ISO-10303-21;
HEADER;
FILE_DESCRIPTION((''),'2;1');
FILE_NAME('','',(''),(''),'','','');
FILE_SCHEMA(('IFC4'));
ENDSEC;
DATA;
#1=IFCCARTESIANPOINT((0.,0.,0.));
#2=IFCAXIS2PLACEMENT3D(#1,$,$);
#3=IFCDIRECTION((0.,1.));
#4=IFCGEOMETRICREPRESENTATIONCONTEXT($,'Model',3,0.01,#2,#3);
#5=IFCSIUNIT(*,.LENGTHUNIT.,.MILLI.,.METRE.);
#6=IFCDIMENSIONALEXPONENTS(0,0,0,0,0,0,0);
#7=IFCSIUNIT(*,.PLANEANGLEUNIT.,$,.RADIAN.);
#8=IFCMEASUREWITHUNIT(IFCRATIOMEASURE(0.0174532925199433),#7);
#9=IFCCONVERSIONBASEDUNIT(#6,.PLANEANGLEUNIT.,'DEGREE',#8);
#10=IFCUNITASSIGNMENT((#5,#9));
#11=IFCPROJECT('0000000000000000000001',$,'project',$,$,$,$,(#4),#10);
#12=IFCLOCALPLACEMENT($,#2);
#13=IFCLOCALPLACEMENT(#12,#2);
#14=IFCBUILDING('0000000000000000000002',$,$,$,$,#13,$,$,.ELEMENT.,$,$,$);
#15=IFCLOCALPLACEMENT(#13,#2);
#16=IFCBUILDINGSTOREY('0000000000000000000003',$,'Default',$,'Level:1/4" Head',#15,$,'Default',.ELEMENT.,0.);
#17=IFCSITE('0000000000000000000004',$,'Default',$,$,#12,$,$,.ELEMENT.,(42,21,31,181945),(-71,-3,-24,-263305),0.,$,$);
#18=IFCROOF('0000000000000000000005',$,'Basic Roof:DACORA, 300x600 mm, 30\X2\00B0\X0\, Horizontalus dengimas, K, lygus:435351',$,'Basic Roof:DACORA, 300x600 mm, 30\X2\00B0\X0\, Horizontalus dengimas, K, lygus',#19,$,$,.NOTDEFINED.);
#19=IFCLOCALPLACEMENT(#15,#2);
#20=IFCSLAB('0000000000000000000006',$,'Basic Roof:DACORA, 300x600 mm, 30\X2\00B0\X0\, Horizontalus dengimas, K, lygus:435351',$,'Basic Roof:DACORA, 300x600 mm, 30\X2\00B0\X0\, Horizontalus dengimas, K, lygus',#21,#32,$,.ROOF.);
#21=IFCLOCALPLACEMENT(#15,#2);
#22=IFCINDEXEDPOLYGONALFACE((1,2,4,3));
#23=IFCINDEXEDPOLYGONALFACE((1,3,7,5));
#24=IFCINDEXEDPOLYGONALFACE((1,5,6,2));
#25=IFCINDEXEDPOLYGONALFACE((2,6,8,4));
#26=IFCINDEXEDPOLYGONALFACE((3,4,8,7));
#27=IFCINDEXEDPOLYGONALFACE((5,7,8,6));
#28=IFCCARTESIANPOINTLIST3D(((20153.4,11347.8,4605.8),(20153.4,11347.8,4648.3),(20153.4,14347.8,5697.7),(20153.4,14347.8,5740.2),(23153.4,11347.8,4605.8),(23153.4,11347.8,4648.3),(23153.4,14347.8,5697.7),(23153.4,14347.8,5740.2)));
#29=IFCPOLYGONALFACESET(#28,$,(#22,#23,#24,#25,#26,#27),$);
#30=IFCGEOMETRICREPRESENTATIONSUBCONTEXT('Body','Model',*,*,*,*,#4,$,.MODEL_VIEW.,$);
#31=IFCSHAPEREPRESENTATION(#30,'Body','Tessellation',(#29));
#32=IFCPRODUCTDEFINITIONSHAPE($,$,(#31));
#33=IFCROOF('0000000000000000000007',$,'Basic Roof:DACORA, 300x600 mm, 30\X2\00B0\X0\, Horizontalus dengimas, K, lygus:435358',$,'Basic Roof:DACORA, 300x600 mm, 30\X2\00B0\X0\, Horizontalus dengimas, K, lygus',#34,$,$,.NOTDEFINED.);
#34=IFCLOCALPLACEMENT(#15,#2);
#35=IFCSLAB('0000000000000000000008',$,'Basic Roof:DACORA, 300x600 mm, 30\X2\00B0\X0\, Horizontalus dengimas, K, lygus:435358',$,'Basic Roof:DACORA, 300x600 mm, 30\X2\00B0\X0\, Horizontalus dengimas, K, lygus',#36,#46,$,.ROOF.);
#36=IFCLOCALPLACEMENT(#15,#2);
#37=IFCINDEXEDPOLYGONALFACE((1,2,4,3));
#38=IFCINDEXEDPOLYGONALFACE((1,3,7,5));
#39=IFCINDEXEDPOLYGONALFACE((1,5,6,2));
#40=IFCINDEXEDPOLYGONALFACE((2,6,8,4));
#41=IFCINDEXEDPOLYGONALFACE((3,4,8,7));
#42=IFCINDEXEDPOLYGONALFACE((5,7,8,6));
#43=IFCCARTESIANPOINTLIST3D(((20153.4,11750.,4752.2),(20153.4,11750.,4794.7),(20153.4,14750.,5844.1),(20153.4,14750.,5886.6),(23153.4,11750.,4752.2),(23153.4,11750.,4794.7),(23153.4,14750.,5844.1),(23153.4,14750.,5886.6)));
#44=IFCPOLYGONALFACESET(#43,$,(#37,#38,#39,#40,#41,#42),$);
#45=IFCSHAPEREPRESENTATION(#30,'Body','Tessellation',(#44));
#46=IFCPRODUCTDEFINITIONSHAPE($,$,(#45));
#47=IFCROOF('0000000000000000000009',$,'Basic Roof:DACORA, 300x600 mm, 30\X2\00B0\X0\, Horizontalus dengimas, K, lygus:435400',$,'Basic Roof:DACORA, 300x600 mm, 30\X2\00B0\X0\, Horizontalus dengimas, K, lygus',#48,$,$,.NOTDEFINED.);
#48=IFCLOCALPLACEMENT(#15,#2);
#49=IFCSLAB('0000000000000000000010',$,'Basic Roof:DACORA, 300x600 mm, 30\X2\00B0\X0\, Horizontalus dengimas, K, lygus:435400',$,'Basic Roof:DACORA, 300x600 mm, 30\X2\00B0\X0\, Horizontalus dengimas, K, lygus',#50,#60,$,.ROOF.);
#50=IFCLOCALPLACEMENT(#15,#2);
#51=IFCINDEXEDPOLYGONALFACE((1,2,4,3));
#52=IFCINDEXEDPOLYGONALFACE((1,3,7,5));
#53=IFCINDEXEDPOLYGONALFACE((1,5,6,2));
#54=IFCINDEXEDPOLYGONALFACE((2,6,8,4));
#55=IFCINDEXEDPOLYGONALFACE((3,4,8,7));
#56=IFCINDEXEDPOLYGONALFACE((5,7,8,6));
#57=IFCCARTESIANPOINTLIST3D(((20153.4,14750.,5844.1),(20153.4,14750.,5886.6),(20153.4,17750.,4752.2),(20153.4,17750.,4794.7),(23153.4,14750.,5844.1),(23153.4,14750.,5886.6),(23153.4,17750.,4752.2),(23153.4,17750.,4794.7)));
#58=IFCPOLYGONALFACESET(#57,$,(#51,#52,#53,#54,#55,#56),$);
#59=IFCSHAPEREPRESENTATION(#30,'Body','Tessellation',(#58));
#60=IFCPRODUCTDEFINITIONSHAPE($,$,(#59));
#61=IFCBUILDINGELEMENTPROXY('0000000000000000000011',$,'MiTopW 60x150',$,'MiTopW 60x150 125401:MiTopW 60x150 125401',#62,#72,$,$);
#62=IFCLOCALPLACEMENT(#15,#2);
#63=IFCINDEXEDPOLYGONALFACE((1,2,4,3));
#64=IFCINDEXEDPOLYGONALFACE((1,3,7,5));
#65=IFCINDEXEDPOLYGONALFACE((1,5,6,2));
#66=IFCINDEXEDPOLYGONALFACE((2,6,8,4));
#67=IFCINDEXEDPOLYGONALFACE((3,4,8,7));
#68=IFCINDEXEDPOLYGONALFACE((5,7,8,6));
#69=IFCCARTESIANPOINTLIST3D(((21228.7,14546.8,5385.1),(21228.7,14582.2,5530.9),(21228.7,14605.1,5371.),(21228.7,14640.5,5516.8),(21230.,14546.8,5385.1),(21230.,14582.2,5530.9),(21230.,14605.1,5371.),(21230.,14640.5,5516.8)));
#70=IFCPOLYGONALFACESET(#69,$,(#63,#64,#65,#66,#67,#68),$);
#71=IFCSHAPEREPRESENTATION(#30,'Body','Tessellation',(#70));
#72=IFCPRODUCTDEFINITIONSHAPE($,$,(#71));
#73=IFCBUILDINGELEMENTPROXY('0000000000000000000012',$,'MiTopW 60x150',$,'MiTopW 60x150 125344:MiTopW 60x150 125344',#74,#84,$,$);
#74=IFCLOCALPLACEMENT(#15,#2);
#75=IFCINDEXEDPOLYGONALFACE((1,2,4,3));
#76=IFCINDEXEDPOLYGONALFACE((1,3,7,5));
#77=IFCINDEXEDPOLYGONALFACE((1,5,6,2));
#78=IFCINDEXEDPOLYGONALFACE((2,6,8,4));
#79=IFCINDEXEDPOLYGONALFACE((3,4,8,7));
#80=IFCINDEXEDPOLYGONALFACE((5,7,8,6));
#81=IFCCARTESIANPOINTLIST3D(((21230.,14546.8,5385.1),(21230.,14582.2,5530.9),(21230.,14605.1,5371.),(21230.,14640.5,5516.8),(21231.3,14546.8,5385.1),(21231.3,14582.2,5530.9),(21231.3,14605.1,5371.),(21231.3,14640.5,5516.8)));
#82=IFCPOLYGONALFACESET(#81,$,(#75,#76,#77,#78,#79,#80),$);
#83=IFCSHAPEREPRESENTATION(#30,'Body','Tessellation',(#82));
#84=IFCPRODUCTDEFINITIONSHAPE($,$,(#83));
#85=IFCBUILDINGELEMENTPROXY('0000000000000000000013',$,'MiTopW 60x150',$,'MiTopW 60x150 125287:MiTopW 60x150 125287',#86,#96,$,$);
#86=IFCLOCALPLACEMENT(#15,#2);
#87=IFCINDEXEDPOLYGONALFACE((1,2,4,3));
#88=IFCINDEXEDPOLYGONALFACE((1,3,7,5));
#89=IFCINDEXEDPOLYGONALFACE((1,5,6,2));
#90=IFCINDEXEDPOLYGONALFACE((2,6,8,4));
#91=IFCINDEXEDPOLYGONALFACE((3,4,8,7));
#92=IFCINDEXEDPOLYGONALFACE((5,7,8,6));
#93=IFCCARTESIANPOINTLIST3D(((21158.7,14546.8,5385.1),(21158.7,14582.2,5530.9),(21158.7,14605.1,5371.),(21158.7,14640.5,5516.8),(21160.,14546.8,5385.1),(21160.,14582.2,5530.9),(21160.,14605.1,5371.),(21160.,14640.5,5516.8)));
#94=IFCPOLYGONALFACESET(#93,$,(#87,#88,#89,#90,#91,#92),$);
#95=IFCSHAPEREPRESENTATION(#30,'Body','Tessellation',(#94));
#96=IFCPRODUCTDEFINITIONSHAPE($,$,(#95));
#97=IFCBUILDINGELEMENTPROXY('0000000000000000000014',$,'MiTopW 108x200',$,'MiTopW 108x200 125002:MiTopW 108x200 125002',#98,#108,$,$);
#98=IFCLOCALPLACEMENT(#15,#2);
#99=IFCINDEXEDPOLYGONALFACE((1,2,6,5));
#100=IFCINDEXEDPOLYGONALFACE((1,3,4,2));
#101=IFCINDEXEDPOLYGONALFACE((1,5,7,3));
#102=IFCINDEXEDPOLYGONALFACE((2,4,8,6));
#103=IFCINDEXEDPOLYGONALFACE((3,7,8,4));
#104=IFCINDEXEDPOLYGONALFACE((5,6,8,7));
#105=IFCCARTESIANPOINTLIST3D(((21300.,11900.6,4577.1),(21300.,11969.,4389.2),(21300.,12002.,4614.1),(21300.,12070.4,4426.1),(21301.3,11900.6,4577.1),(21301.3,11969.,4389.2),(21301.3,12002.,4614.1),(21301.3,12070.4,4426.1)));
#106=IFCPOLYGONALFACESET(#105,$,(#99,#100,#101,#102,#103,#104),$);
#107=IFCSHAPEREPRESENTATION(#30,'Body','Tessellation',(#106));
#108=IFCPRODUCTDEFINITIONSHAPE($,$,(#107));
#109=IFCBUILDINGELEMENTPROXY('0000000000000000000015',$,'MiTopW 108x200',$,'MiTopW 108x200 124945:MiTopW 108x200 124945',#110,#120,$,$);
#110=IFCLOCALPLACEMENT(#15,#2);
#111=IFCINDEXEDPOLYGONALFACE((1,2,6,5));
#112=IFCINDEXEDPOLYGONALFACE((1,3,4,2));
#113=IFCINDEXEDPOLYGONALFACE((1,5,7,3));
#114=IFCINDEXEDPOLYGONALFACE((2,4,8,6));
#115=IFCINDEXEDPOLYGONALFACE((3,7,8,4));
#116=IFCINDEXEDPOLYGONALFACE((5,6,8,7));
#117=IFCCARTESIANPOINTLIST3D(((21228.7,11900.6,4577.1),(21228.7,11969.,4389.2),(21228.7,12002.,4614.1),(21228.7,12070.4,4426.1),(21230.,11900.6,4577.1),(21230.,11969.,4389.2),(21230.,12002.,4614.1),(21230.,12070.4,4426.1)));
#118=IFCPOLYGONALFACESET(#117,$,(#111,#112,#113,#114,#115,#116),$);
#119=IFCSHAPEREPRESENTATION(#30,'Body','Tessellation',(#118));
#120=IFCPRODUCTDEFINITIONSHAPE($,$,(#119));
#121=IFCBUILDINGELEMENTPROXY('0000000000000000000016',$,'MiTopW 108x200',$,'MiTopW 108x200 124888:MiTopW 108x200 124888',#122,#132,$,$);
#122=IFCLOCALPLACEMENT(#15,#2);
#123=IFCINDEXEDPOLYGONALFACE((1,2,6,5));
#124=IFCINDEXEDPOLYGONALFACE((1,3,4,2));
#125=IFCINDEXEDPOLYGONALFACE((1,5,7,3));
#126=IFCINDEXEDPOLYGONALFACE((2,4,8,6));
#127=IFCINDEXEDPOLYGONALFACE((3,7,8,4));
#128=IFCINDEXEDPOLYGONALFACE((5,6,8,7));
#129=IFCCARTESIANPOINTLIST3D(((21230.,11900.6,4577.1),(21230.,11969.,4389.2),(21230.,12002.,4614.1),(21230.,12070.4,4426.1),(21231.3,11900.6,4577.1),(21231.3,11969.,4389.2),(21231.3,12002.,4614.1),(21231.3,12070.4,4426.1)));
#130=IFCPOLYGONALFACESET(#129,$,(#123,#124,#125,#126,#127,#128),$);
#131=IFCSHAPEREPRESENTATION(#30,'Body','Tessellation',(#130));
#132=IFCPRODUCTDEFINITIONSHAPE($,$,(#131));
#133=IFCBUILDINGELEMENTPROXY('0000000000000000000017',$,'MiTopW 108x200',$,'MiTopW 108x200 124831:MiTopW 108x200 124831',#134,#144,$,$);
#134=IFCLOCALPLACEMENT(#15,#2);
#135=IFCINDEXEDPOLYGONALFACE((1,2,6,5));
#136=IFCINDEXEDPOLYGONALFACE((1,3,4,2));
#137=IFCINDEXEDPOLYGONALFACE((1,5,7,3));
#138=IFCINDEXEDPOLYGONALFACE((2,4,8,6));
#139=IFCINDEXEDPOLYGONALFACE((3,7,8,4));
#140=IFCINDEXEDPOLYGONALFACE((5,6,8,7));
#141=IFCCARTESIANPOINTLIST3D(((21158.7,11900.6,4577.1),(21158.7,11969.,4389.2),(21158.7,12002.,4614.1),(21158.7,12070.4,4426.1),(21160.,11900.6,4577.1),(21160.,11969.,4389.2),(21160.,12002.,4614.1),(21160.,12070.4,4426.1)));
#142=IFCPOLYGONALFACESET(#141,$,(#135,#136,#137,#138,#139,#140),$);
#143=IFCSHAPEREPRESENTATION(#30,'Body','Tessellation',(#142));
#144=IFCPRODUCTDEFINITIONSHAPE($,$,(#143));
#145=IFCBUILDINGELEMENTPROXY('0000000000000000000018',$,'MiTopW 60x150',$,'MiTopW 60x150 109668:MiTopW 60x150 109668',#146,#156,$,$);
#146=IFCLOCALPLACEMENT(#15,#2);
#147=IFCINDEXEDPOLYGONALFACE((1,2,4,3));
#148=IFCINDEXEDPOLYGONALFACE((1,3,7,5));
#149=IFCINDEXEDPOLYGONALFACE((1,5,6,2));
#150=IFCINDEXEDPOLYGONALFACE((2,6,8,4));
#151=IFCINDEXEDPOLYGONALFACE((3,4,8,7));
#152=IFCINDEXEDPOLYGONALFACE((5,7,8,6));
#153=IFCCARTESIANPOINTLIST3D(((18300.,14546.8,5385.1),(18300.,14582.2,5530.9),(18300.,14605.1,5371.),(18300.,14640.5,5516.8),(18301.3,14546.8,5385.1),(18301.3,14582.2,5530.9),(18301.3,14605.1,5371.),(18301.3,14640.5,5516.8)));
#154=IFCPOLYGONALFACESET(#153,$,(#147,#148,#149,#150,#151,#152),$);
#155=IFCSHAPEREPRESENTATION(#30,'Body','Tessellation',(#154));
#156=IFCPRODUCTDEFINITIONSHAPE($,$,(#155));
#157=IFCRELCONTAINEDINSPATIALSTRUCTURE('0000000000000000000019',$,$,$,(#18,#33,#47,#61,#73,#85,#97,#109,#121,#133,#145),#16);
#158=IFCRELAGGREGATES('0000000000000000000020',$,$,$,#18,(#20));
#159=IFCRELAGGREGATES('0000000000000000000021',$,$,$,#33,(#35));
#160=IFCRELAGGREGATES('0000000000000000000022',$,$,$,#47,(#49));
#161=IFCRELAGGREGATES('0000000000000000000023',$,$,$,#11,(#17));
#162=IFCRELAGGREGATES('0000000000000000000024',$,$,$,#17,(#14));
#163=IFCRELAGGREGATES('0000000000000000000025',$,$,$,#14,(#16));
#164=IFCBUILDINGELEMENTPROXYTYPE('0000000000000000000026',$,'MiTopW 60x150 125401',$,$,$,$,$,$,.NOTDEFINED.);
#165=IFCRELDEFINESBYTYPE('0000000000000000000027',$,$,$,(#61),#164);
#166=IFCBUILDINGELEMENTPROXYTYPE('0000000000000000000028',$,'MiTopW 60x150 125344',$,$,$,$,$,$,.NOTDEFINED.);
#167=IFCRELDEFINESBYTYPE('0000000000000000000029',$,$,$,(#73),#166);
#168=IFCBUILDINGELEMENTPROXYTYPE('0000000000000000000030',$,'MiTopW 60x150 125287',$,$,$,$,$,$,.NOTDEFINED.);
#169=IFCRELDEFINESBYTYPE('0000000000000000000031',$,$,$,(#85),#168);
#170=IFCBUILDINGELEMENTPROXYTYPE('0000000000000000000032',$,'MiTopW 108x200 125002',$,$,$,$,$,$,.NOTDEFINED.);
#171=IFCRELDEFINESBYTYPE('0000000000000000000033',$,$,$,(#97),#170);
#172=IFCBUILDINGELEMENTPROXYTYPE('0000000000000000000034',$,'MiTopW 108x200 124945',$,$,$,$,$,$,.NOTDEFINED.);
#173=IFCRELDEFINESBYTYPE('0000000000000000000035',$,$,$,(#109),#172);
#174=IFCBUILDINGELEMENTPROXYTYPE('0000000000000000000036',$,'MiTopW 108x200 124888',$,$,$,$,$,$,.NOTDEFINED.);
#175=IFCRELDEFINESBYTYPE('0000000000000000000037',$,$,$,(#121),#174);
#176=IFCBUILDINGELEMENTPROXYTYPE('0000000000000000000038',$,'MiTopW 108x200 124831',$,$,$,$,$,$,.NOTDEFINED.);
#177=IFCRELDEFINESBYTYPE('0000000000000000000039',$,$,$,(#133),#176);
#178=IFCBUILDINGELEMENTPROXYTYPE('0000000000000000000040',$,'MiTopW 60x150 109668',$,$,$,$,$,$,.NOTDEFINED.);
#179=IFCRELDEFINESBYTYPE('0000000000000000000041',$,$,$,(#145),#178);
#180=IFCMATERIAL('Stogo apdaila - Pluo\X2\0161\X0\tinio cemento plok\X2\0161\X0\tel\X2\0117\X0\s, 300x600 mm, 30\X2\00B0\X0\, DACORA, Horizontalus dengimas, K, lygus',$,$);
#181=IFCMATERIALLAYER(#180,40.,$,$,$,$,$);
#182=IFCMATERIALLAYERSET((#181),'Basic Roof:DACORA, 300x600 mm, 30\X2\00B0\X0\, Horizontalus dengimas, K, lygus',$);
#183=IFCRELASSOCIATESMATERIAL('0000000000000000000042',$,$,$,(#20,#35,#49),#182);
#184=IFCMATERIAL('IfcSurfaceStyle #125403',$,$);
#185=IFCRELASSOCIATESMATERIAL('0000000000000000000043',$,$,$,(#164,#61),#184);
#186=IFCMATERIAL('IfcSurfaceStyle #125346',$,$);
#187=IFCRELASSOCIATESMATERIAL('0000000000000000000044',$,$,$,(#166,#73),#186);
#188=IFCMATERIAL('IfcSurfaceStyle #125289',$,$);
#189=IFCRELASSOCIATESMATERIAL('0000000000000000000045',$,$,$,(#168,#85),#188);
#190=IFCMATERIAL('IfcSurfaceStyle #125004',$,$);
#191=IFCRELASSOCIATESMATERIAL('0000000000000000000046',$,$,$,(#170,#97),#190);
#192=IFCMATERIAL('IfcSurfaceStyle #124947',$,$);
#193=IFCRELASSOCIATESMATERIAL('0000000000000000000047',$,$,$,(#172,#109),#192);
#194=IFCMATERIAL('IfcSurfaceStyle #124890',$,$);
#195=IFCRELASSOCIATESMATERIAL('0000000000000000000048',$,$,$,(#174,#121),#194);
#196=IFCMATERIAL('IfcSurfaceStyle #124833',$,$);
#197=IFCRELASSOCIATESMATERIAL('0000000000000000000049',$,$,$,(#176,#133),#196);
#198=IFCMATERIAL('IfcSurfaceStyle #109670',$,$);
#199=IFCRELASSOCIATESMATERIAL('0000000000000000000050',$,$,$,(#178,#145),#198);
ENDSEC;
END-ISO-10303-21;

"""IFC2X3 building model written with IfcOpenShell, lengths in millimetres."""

from ifc_helpers import new_model, entity, si_unit, converted_unit, direction, frame, frame_2d, origin, place, context, subcontext, project, spatial, polyline, rectangle, outline, extrude, source, transform, mapped, material, layer, layer_set, type_object, type_shapes, element, aggregate, save


model = new_model("IFC2X3")

# Units and contexts
model_context = context("Model", 3, precision=0.01, world=origin(), true_north=direction((0.0, 1.0)))
body_context = subcontext(model_context, "Body", "Model", "MODEL_VIEW")
ifc_project = project(units=[si_unit("LENGTHUNIT", "METRE", prefix="MILLI"), converted_unit("PLANEANGLEUNIT", "DEGREE", entity("IfcRatioMeasure", 0.0174532925199433), si_unit("PLANEANGLEUNIT", "RADIAN"), dimensions=[0, 0, 0, 0, 0, 0, 0])], contexts=[model_context])

# Site, building, storey
site_placement = place(None, origin())
site = spatial("IfcSite", under=ifc_project, at=site_placement, Name="Default", CompositionType="ELEMENT", RefLatitude=(42, 21, 31, 181945), RefLongitude=(-71, -3, -24, -263305), RefElevation=0.0)
building_placement = place(site_placement, origin())
building = spatial("IfcBuilding", under=site, at=building_placement, CompositionType="ELEMENT")
storey_placement = place(building_placement, origin())
storey = spatial("IfcBuildingStorey", under=building, at=storey_placement, Name="Default", ObjectType="Level:1/4\" Head", LongName="Default", CompositionType="ELEMENT", Elevation=0.0)

# Roofs, slabs
roof_1_placement = place(storey_placement, frame((20153.4, 11347.8, 4605.8)))
roof_1 = element("IfcRoof", 1, at=roof_1_placement, inside=storey, Name="Basic Roof:DACORA, 300x600 mm, 30°, Horizontalus dengimas, K, lygus:435351", ObjectType="Basic Roof:DACORA, 300x600 mm, 30°, Horizontalus dengimas, K, lygus", ShapeType="NOTDEFINED")
ifc_material_1 = material(Name="Stogo apdaila - Pluoštinio cemento plokštelės, 300x600 mm, 30°, DACORA, Horizontalus dengimas, K, lygus")
ifc_layer = layer(ifc_material_1, 40.0)
ifc_layer_set = layer_set([ifc_layer], Name="Basic Roof:DACORA, 300x600 mm, 30°, Horizontalus dengimas, K, lygus")
slab_1_placement = place(roof_1_placement, origin())
slab_1 = element("IfcSlab", 2, at=slab_1_placement, material=ifc_layer_set, Name="Basic Roof:DACORA, 300x600 mm, 30°, Horizontalus dengimas, K, lygus:435351", ObjectType="Basic Roof:DACORA, 300x600 mm, 30°, Horizontalus dengimas, K, lygus", PredefinedType="ROOF", context=body_context, shape_type="SweptSolid", body=[
    extrude(rectangle(XDim=3192.5, YDim=3000.0, at=frame_2d((0.0, 0.0), x_axis=(0.0, -1.0))), frame((1500.0, 1500.0, 546.0), z_axis=(0.0, -0.34202, 0.939693), x_axis=(1.0, 0.0, 0.0)), (0.0, 0.34202, 0.939693), 42.6),
])
aggregate(roof_1, [slab_1])
roof_2_placement = place(storey_placement, frame((20153.4, 11750.0, 4752.2)))
roof_2 = element("IfcRoof", 3, at=roof_2_placement, inside=storey, Name="Basic Roof:DACORA, 300x600 mm, 30°, Horizontalus dengimas, K, lygus:435358", ObjectType="Basic Roof:DACORA, 300x600 mm, 30°, Horizontalus dengimas, K, lygus", ShapeType="NOTDEFINED")
slab_2_placement = place(roof_2_placement, origin())
slab_2 = element("IfcSlab", 4, at=slab_2_placement, material=ifc_layer_set, Name="Basic Roof:DACORA, 300x600 mm, 30°, Horizontalus dengimas, K, lygus:435358", ObjectType="Basic Roof:DACORA, 300x600 mm, 30°, Horizontalus dengimas, K, lygus", PredefinedType="ROOF", context=body_context, shape_type="SweptSolid", body=[
    extrude(rectangle(XDim=3192.5, YDim=3000.0, at=frame_2d((0.0, 0.0), x_axis=(0.0, -1.0))), frame((1500.0, 1500.0, 546.0), z_axis=(0.0, -0.34202, 0.939693), x_axis=(1.0, 0.0, 0.0)), (0.0, 0.34202, 0.939693), 42.6),
])
aggregate(roof_2, [slab_2])
roof_3_placement = place(storey_placement, frame((20153.4, 14750.0, 4752.2)))
roof_3 = element("IfcRoof", 5, at=roof_3_placement, inside=storey, Name="Basic Roof:DACORA, 300x600 mm, 30°, Horizontalus dengimas, K, lygus:435400", ObjectType="Basic Roof:DACORA, 300x600 mm, 30°, Horizontalus dengimas, K, lygus", ShapeType="NOTDEFINED")
slab_3_placement = place(roof_3_placement, origin())
slab_3 = element("IfcSlab", 6, at=slab_3_placement, material=ifc_layer_set, Name="Basic Roof:DACORA, 300x600 mm, 30°, Horizontalus dengimas, K, lygus:435400", ObjectType="Basic Roof:DACORA, 300x600 mm, 30°, Horizontalus dengimas, K, lygus", PredefinedType="ROOF", context=body_context, shape_type="SweptSolid", body=[
    extrude(rectangle(XDim=3192.5, YDim=3000.0, at=frame_2d((0.0, 0.0), x_axis=(0.0, 1.0))), frame((1500.0, 1500.0, 546.0), z_axis=(0.0, 0.34202, 0.939693), x_axis=(1.0, 0.0, 0.0)), (0.0, -0.34202, 0.939693), 42.6),
])
aggregate(roof_3, [slab_3])

# Building element proxies
ifc_material_2 = material(Name="IfcSurfaceStyle #125403")
building_element_proxy_type_1 = type_object("IfcBuildingElementProxyType", Name="MiTopW 60x150 125401", PredefinedType="NOTDEFINED", material=ifc_material_2)
shared_shape_1 = source(origin(), body_context, "Body", "SweptSolid", [
    extrude(outline(polyline([(-75.0, -30.0), (75.0, -30.0), (75.0, 30.0), (-75.0, 30.0), (-75.0, -30.0)])), frame((75.0, 30.0, 0.0), z_axis=(0.0, 0.0, 1.0), x_axis=(-1.0, 0.0, 0.0)), (0.0, 0.0, 1.0), 1.3),
])
type_shapes(building_element_proxy_type_1, [shared_shape_1])
proxy_1_placement = place(building_placement, frame((21230.0, 14640.5, 5516.8), z_axis=(-1.0, 0.0, 0.0), x_axis=(0.0, -0.235626, -0.971844)))
element("IfcBuildingElementProxy", 7, at=proxy_1_placement, inside=storey, type_object=building_element_proxy_type_1, material=ifc_material_2, Name="MiTopW 60x150", ObjectType="MiTopW 60x150 125401:MiTopW 60x150 125401", context=body_context, shape_type="MappedRepresentation", body=[
    mapped(shared_shape_1, transform((0.0, 0.0, 0.0), scale=1.0)),
])
ifc_material_3 = material(Name="IfcSurfaceStyle #125346")
building_element_proxy_type_2 = type_object("IfcBuildingElementProxyType", Name="MiTopW 60x150 125344", PredefinedType="NOTDEFINED", material=ifc_material_3)
shared_shape_2 = source(origin(), body_context, "Body", "SweptSolid", [
    extrude(outline(polyline([(-75.0, -30.0), (75.0, -30.0), (75.0, 30.0), (-75.0, 30.0), (-75.0, -30.0)])), frame((75.0, 30.0, 0.0), z_axis=(0.0, 0.0, 1.0), x_axis=(-1.0, 0.0, 0.0)), (0.0, 0.0, 1.0), 1.3),
])
type_shapes(building_element_proxy_type_2, [shared_shape_2])
proxy_2_placement = place(building_placement, frame((21231.3, 14640.5, 5516.8), z_axis=(-1.0, 0.0, 0.0), x_axis=(0.0, -0.235626, -0.971844)))
element("IfcBuildingElementProxy", 8, at=proxy_2_placement, inside=storey, type_object=building_element_proxy_type_2, material=ifc_material_3, Name="MiTopW 60x150", ObjectType="MiTopW 60x150 125344:MiTopW 60x150 125344", context=body_context, shape_type="MappedRepresentation", body=[
    mapped(shared_shape_2, transform((0.0, 0.0, 0.0), scale=1.0)),
])
ifc_material_4 = material(Name="IfcSurfaceStyle #125289")
building_element_proxy_type_3 = type_object("IfcBuildingElementProxyType", Name="MiTopW 60x150 125287", PredefinedType="NOTDEFINED", material=ifc_material_4)
shared_shape_3 = source(origin(), body_context, "Body", "SweptSolid", [
    extrude(outline(polyline([(-75.0, -30.0), (75.0, -30.0), (75.0, 30.0), (-75.0, 30.0), (-75.0, -30.0)])), frame((75.0, 30.0, 0.0), z_axis=(0.0, 0.0, 1.0), x_axis=(-1.0, 0.0, 0.0)), (0.0, 0.0, 1.0), 1.3),
])
type_shapes(building_element_proxy_type_3, [shared_shape_3])
proxy_3_placement = place(building_placement, frame((21160.0, 14640.5, 5516.8), z_axis=(-1.0, 0.0, 0.0), x_axis=(0.0, -0.235626, -0.971844)))
element("IfcBuildingElementProxy", 9, at=proxy_3_placement, inside=storey, type_object=building_element_proxy_type_3, material=ifc_material_4, Name="MiTopW 60x150", ObjectType="MiTopW 60x150 125287:MiTopW 60x150 125287", context=body_context, shape_type="MappedRepresentation", body=[
    mapped(shared_shape_3, transform((0.0, 0.0, 0.0), scale=1.0)),
])
ifc_material_5 = material(Name="IfcSurfaceStyle #125004")
building_element_proxy_type_4 = type_object("IfcBuildingElementProxyType", Name="MiTopW 108x200 125002", PredefinedType="NOTDEFINED", material=ifc_material_5)
shared_shape_4 = source(origin(), body_context, "Body", "SweptSolid", [
    extrude(outline(polyline([(-54.0, -100.0), (54.0, -100.0), (54.0, 100.0), (-54.0, 100.0), (-54.0, -100.0)])), frame((100.0, 54.0, 0.0), z_axis=(0.0, 0.0, 1.0), x_axis=(-0.000002, 1.0, 0.0)), (0.0, 0.0, 1.0), 1.3),
])
type_shapes(building_element_proxy_type_4, [shared_shape_4])
proxy_4_placement = place(building_placement, frame((21301.3, 12002.0, 4614.1), z_axis=(-1.0, 0.0, 0.0), x_axis=(0.0, 0.34202, -0.939693)))
element("IfcBuildingElementProxy", 10, at=proxy_4_placement, inside=storey, type_object=building_element_proxy_type_4, material=ifc_material_5, Name="MiTopW 108x200", ObjectType="MiTopW 108x200 125002:MiTopW 108x200 125002", context=body_context, shape_type="MappedRepresentation", body=[
    mapped(shared_shape_4, transform((0.0, 0.0, 0.0), scale=1.0)),
])
ifc_material_6 = material(Name="IfcSurfaceStyle #124947")
building_element_proxy_type_5 = type_object("IfcBuildingElementProxyType", Name="MiTopW 108x200 124945", PredefinedType="NOTDEFINED", material=ifc_material_6)
shared_shape_5 = source(origin(), body_context, "Body", "SweptSolid", [
    extrude(outline(polyline([(-54.0, -100.0), (54.0, -100.0), (54.0, 100.0), (-54.0, 100.0), (-54.0, -100.0)])), frame((100.0, 54.0, 0.0), z_axis=(0.0, 0.0, 1.0), x_axis=(-0.000002, 1.0, 0.0)), (0.0, 0.0, 1.0), 1.3),
])
type_shapes(building_element_proxy_type_5, [shared_shape_5])
proxy_5_placement = place(building_placement, frame((21230.0, 12002.0, 4614.1), z_axis=(-1.0, 0.0, 0.0), x_axis=(0.0, 0.34202, -0.939693)))
element("IfcBuildingElementProxy", 11, at=proxy_5_placement, inside=storey, type_object=building_element_proxy_type_5, material=ifc_material_6, Name="MiTopW 108x200", ObjectType="MiTopW 108x200 124945:MiTopW 108x200 124945", context=body_context, shape_type="MappedRepresentation", body=[
    mapped(shared_shape_5, transform((0.0, 0.0, 0.0), scale=1.0)),
])
ifc_material_7 = material(Name="IfcSurfaceStyle #124890")
building_element_proxy_type_6 = type_object("IfcBuildingElementProxyType", Name="MiTopW 108x200 124888", PredefinedType="NOTDEFINED", material=ifc_material_7)
shared_shape_6 = source(origin(), body_context, "Body", "SweptSolid", [
    extrude(outline(polyline([(-54.0, -100.0), (54.0, -100.0), (54.0, 100.0), (-54.0, 100.0), (-54.0, -100.0)])), frame((100.0, 54.0, 0.0), z_axis=(0.0, 0.0, 1.0), x_axis=(-0.000002, 1.0, 0.0)), (0.0, 0.0, 1.0), 1.3),
])
type_shapes(building_element_proxy_type_6, [shared_shape_6])
proxy_6_placement = place(building_placement, frame((21231.3, 12002.0, 4614.1), z_axis=(-1.0, 0.0, 0.0), x_axis=(0.0, 0.34202, -0.939693)))
element("IfcBuildingElementProxy", 12, at=proxy_6_placement, inside=storey, type_object=building_element_proxy_type_6, material=ifc_material_7, Name="MiTopW 108x200", ObjectType="MiTopW 108x200 124888:MiTopW 108x200 124888", context=body_context, shape_type="MappedRepresentation", body=[
    mapped(shared_shape_6, transform((0.0, 0.0, 0.0), scale=1.0)),
])
ifc_material_8 = material(Name="IfcSurfaceStyle #124833")
building_element_proxy_type_7 = type_object("IfcBuildingElementProxyType", Name="MiTopW 108x200 124831", PredefinedType="NOTDEFINED", material=ifc_material_8)
shared_shape_7 = source(origin(), body_context, "Body", "SweptSolid", [
    extrude(outline(polyline([(-54.0, -100.0), (54.0, -100.0), (54.0, 100.0), (-54.0, 100.0), (-54.0, -100.0)])), frame((100.0, 54.0, 0.0), z_axis=(0.0, 0.0, 1.0), x_axis=(-0.000002, 1.0, 0.0)), (0.0, 0.0, 1.0), 1.3),
])
type_shapes(building_element_proxy_type_7, [shared_shape_7])
proxy_7_placement = place(building_placement, frame((21160.0, 12002.0, 4614.1), z_axis=(-1.0, 0.0, 0.0), x_axis=(0.0, 0.34202, -0.939693)))
element("IfcBuildingElementProxy", 13, at=proxy_7_placement, inside=storey, type_object=building_element_proxy_type_7, material=ifc_material_8, Name="MiTopW 108x200", ObjectType="MiTopW 108x200 124831:MiTopW 108x200 124831", context=body_context, shape_type="MappedRepresentation", body=[
    mapped(shared_shape_7, transform((0.0, 0.0, 0.0), scale=1.0)),
])
ifc_material_9 = material(Name="IfcSurfaceStyle #109670")
building_element_proxy_type_8 = type_object("IfcBuildingElementProxyType", Name="MiTopW 60x150 109668", PredefinedType="NOTDEFINED", material=ifc_material_9)
shared_shape_8 = source(origin(), body_context, "Body", "SweptSolid", [
    extrude(outline(polyline([(-75.0, -30.0), (75.0, -30.0), (75.0, 30.0), (-75.0, 30.0), (-75.0, -30.0)])), frame((75.0, 30.0, 0.0), z_axis=(0.0, 0.0, 1.0), x_axis=(-1.0, 0.0, 0.0)), (0.0, 0.0, 1.0), 1.3),
])
type_shapes(building_element_proxy_type_8, [shared_shape_8])
proxy_8_placement = place(building_placement, frame((18301.3, 14640.5, 5516.8), z_axis=(-1.0, 0.0, 0.0), x_axis=(0.0, -0.235626, -0.971844)))
element("IfcBuildingElementProxy", 14, at=proxy_8_placement, inside=storey, type_object=building_element_proxy_type_8, material=ifc_material_9, Name="MiTopW 60x150", ObjectType="MiTopW 60x150 109668:MiTopW 60x150 109668", context=body_context, shape_type="MappedRepresentation", body=[
    mapped(shared_shape_8, transform((0.0, 0.0, 0.0), scale=1.0)),
])

save(model, "model.ifc")
